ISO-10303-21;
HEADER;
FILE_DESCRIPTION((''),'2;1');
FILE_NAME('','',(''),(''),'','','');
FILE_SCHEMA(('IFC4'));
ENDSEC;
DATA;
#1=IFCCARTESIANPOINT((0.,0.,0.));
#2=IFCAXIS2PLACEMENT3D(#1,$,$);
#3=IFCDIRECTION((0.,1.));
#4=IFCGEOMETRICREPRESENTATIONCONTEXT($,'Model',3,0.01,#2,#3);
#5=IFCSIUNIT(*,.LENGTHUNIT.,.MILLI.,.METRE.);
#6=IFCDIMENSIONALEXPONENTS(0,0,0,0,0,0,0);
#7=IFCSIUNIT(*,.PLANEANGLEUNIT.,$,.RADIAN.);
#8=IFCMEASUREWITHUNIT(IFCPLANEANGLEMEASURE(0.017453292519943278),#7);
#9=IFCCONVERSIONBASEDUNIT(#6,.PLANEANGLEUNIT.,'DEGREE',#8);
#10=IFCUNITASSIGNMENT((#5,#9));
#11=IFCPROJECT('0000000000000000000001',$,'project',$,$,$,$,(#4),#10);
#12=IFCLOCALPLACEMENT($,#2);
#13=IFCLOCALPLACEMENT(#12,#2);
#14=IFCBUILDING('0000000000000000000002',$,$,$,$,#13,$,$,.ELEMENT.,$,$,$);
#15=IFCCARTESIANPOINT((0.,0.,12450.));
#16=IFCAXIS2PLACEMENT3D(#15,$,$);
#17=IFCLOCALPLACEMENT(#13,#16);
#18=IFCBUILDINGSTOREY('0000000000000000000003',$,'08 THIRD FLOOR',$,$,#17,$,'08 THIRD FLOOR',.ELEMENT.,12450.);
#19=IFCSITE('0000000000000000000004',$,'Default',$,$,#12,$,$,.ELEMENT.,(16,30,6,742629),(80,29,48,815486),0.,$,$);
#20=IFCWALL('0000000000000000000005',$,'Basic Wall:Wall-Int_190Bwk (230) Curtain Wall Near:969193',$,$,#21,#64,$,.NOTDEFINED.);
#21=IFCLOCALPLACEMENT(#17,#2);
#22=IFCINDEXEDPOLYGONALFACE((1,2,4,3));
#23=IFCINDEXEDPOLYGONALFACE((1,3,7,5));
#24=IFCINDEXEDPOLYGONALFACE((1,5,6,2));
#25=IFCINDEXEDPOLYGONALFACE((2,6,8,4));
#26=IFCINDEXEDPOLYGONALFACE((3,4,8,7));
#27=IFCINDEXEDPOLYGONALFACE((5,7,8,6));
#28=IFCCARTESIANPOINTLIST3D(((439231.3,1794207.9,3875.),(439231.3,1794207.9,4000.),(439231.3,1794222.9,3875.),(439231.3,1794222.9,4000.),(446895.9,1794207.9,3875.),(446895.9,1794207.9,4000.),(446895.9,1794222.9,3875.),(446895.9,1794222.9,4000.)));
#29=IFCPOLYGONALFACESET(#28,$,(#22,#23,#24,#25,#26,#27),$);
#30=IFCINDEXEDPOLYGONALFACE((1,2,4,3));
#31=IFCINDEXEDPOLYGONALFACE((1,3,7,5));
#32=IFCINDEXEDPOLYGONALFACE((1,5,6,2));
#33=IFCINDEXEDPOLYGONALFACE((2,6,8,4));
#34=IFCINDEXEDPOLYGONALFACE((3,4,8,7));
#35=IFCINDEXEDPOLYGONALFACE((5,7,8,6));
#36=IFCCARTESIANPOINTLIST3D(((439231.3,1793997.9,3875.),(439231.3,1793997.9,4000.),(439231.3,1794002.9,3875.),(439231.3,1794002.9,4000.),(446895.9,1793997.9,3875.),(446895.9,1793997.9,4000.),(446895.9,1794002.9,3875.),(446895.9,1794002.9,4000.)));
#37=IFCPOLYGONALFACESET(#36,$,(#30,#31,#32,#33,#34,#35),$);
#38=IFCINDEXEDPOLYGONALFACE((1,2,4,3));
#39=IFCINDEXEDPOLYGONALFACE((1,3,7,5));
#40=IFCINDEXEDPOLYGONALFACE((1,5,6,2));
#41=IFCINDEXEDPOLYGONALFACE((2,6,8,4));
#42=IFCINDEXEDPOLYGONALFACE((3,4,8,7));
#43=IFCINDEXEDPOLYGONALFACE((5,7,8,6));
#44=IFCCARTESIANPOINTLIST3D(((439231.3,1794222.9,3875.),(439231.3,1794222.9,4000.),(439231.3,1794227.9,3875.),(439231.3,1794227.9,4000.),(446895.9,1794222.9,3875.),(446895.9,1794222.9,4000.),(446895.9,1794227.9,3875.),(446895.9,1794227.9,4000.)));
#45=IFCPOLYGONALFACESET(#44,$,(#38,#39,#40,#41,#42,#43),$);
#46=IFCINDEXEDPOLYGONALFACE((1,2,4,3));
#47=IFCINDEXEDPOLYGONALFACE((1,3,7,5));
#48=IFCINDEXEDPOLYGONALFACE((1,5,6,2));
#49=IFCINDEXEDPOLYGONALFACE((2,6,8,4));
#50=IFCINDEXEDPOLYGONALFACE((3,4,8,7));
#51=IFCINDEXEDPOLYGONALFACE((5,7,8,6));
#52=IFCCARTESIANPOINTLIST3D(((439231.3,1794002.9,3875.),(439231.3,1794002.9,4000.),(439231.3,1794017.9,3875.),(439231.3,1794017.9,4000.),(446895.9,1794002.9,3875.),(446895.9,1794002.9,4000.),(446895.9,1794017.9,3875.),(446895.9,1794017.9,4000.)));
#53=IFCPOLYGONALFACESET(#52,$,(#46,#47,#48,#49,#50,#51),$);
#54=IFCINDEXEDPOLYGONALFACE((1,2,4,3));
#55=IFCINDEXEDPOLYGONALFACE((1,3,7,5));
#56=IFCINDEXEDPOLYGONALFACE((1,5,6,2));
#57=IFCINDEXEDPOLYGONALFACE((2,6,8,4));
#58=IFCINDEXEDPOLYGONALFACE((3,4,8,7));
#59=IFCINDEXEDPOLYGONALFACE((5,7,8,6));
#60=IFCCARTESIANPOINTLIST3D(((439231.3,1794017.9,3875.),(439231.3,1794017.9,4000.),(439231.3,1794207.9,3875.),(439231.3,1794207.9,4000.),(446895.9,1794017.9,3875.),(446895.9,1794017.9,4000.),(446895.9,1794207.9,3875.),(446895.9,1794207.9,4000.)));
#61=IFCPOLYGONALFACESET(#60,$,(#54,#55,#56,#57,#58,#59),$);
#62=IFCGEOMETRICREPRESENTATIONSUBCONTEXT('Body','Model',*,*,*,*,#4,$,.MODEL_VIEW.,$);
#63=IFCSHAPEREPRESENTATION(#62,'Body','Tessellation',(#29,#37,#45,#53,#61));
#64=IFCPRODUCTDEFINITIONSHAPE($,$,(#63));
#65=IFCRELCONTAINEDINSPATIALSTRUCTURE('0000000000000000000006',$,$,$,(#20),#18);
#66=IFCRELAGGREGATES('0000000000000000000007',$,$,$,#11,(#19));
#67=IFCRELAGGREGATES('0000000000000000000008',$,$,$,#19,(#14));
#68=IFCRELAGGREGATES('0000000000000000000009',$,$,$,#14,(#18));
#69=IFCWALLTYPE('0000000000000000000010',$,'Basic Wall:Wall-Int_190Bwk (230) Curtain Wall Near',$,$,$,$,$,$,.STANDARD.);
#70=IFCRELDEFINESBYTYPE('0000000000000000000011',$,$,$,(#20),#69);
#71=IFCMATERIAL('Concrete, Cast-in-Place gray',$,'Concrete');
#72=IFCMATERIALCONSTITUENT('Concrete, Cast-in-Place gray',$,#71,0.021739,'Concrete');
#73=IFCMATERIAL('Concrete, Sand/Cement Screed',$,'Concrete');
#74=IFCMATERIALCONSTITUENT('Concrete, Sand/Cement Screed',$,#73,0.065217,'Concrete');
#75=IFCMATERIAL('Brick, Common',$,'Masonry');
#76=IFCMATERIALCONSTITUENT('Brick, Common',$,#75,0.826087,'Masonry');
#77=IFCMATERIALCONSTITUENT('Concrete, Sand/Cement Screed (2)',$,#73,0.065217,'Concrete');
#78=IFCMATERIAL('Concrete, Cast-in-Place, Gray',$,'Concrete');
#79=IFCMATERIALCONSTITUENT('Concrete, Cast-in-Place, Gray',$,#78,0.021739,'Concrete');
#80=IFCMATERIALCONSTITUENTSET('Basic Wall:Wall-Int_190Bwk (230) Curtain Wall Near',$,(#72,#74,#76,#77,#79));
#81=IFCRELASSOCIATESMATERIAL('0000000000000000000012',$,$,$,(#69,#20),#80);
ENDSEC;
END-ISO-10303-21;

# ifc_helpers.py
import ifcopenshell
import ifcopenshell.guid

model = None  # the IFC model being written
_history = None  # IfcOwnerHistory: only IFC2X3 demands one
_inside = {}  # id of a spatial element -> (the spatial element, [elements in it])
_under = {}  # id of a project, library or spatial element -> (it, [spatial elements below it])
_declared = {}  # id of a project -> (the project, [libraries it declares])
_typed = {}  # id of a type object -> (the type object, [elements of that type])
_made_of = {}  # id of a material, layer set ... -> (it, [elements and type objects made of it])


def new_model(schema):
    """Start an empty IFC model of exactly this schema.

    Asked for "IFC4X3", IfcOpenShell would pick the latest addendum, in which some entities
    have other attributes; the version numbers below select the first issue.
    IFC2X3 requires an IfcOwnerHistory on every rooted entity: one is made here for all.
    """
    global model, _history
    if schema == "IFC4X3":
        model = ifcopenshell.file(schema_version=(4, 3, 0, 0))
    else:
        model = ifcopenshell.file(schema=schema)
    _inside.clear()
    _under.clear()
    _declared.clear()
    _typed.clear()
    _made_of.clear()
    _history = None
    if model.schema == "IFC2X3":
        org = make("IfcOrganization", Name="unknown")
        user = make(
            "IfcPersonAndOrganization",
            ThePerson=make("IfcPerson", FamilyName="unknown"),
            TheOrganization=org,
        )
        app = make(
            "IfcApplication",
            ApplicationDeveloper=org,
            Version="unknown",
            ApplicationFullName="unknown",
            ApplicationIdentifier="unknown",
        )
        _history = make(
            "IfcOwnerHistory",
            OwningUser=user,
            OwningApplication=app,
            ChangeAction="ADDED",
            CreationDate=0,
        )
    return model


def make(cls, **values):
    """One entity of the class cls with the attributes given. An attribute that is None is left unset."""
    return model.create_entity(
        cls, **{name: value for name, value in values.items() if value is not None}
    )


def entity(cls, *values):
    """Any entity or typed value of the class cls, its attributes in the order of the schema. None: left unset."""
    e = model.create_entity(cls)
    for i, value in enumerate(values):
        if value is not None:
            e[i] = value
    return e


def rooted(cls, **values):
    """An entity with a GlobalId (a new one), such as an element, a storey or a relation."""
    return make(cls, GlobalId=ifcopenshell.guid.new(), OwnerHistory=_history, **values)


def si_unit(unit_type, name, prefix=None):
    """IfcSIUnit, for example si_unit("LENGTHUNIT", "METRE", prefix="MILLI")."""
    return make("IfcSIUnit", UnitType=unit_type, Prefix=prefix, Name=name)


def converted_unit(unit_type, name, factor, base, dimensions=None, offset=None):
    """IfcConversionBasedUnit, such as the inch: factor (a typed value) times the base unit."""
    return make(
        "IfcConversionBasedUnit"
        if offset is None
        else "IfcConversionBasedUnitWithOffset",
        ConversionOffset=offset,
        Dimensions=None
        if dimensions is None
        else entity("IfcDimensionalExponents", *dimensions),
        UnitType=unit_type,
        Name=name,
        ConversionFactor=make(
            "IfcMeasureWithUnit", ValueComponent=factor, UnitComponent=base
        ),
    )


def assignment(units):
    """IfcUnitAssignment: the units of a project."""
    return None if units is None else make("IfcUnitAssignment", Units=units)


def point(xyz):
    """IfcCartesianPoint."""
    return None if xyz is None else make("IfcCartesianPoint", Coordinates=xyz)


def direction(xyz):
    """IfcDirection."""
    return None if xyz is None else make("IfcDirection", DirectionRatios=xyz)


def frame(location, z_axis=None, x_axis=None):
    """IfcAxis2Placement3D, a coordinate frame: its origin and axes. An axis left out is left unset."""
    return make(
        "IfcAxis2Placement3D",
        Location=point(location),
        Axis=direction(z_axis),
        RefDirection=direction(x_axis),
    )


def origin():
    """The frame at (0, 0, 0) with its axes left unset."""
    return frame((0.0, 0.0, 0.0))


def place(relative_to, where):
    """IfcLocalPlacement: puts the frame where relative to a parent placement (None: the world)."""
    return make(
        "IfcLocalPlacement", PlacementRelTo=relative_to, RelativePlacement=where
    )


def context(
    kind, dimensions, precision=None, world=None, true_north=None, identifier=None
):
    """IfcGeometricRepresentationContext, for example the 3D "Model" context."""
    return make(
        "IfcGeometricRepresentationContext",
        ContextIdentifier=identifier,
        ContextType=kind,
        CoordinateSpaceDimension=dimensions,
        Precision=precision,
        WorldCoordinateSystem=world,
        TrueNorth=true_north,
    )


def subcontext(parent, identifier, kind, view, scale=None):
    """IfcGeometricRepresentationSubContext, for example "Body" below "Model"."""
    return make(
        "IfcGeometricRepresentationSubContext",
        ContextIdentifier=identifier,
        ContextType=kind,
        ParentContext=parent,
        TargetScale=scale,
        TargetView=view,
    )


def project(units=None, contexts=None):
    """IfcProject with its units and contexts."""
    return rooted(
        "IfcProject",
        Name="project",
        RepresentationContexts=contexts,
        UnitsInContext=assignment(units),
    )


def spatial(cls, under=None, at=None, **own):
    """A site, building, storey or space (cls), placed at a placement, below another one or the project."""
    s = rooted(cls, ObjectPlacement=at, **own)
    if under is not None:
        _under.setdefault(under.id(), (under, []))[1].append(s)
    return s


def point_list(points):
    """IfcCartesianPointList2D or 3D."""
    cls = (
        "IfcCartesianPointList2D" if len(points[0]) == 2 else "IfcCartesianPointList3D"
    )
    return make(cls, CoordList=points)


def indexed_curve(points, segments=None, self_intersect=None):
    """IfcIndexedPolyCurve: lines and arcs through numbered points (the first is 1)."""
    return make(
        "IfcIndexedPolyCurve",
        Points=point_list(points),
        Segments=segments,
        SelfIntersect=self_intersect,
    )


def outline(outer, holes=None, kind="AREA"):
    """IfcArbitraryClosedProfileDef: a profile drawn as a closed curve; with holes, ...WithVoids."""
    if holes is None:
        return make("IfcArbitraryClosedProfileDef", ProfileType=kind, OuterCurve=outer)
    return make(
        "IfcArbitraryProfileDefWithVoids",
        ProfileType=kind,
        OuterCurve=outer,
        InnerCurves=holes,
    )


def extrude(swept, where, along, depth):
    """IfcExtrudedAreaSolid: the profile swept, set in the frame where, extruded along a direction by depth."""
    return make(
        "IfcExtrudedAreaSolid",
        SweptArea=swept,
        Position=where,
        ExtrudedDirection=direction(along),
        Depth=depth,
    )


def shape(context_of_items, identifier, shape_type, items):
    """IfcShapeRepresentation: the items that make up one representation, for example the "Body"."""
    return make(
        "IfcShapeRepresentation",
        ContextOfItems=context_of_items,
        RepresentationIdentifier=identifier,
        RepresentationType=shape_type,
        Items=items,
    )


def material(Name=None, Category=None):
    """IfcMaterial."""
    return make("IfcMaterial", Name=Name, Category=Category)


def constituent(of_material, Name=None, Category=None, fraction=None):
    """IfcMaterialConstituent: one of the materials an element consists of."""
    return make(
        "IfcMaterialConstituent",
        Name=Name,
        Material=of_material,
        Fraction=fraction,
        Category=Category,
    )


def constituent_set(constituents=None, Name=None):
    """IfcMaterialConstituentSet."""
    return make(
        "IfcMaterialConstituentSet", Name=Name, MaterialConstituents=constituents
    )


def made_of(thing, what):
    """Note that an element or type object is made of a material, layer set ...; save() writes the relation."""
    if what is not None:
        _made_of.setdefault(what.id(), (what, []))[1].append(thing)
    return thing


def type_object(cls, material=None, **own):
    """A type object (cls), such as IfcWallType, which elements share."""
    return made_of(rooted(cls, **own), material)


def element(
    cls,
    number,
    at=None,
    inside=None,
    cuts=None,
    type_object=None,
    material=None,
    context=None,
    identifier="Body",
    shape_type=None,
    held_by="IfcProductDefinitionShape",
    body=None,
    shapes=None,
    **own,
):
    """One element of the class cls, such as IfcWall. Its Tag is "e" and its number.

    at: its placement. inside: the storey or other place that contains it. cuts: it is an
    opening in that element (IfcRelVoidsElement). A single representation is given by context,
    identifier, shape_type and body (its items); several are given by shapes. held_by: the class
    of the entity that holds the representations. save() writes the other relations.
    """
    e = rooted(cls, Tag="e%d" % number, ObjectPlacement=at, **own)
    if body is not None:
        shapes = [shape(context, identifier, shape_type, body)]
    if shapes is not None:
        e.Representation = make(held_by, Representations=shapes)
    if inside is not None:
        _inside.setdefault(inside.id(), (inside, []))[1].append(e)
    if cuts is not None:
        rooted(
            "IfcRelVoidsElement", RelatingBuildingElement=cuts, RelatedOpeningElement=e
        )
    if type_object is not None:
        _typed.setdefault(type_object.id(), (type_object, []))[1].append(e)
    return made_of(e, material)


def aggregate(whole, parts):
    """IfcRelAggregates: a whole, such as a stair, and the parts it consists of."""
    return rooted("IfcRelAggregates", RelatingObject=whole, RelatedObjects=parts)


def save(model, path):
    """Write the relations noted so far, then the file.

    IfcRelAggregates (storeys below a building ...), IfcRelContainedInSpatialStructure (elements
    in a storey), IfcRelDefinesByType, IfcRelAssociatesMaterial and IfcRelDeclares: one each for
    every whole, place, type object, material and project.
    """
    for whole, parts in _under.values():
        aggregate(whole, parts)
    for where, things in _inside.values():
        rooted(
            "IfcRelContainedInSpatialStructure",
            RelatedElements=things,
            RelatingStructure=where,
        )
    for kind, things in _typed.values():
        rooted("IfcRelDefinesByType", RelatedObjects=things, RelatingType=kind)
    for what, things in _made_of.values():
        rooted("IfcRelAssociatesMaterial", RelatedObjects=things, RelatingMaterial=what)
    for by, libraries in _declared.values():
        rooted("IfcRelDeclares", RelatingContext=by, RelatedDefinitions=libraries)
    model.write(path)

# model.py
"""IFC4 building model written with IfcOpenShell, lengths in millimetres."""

from ifc_helpers import new_model, entity, si_unit, converted_unit, direction, frame, origin, place, context, subcontext, project, spatial, indexed_curve, outline, extrude, material, constituent, constituent_set, type_object, element, save


model = new_model("IFC4")

# Units and contexts
model_context = context("Model", 3, precision=0.01, world=origin(), true_north=direction((0.0, 1.0)))
body_context = subcontext(model_context, "Body", "Model", "MODEL_VIEW")
ifc_project = project(units=[si_unit("LENGTHUNIT", "METRE", prefix="MILLI"), converted_unit("PLANEANGLEUNIT", "DEGREE", entity("IfcPlaneAngleMeasure", 0.017453292519943278), si_unit("PLANEANGLEUNIT", "RADIAN"), dimensions=[0, 0, 0, 0, 0, 0, 0])], contexts=[model_context])

# Site, building, storey
site_placement = place(None, origin())
site = spatial("IfcSite", under=ifc_project, at=site_placement, Name="Default", CompositionType="ELEMENT", RefLatitude=(16, 30, 6, 742629), RefLongitude=(80, 29, 48, 815486), RefElevation=0.0)
building_placement = place(site_placement, origin())
building = spatial("IfcBuilding", under=site, at=building_placement, CompositionType="ELEMENT")
storey_placement = place(building_placement, frame((0.0, 0.0, 12450.0)))
storey = spatial("IfcBuildingStorey", under=building, at=storey_placement, Name="08 THIRD FLOOR", LongName="08 THIRD FLOOR", CompositionType="ELEMENT", Elevation=12450.0)

# Shared definitions
ifc_material_1 = material(Name="Concrete, Sand/Cement Screed", Category="Concrete")
ifc_material_2 = material(Name="Brick, Common", Category="Masonry")

# Wall
ifc_material_3 = material(Name="Concrete, Cast-in-Place gray", Category="Concrete")
ifc_constituent_1 = constituent(ifc_material_3, Name="Concrete, Cast-in-Place gray", Category="Concrete", fraction=0.021739)
ifc_constituent_2 = constituent(ifc_material_1, Name="Concrete, Sand/Cement Screed", Category="Concrete", fraction=0.065217)
ifc_constituent_3 = constituent(ifc_material_2, Name="Brick, Common", Category="Masonry", fraction=0.826087)
ifc_constituent_4 = constituent(ifc_material_1, Name="Concrete, Sand/Cement Screed (2)", Category="Concrete", fraction=0.065217)
ifc_material_4 = material(Name="Concrete, Cast-in-Place, Gray", Category="Concrete")
ifc_constituent_5 = constituent(ifc_material_4, Name="Concrete, Cast-in-Place, Gray", Category="Concrete", fraction=0.021739)
ifc_constituent_set_1 = constituent_set(constituents=[ifc_constituent_1, ifc_constituent_2, ifc_constituent_3, ifc_constituent_4, ifc_constituent_5], Name="Basic Wall:Wall-Int_190Bwk (230) Curtain Wall Near")
wall_type_1 = type_object("IfcWallType", Name="Basic Wall:Wall-Int_190Bwk (230) Curtain Wall Near", PredefinedType="STANDARD", material=ifc_constituent_set_1)
wall_1_placement = place(storey_placement, frame((439231.3, 1794112.9, 3875.0)))
element("IfcWall", 1, at=wall_1_placement, inside=storey, type_object=wall_type_1, material=ifc_constituent_set_1, Name="Basic Wall:Wall-Int_190Bwk (230) Curtain Wall Near:969193", PredefinedType="NOTDEFINED", context=body_context, shape_type="SweptSolid", body=[
    extrude(outline(indexed_curve([(-3832.3, -7.5), (3832.3, -7.5), (3832.3, 7.5), (-3832.3, 7.5), (-3832.3, -7.5)], self_intersect=False)), frame((3832.3, 102.5, 0.0)), (0.0, 0.0, 1.0), 125.0),
    extrude(outline(indexed_curve([(-2.5, -3832.3), (2.5, -3832.3), (2.5, 3832.3), (-2.5, 3832.3), (-2.5, -3832.3)], self_intersect=False)), frame((3832.3, -112.5, 0.0), z_axis=(0.0, 0.0, 1.0), x_axis=(0.0, 1.0, 0.0)), (0.0, 0.0, 1.0), 125.0),
    extrude(outline(indexed_curve([(-2.5, -3832.3), (2.5, -3832.3), (2.5, 3832.3), (-2.5, 3832.3), (-2.5, -3832.3)], self_intersect=False)), frame((3832.3, 112.5, 0.0), z_axis=(0.0, 0.0, 1.0), x_axis=(0.0, -1.0, 0.0)), (0.0, 0.0, 1.0), 125.0),
    extrude(outline(indexed_curve([(-3832.3, -7.5), (3832.3, -7.5), (3832.3, 7.5), (-3832.3, 7.5), (-3832.3, -7.5)], self_intersect=False)), frame((3832.3, -102.5, 0.0)), (0.0, 0.0, 1.0), 125.0),
    extrude(outline(indexed_curve([(-3832.3, -95.0), (3832.3, -95.0), (3832.3, 95.0), (-3832.3, 95.0), (-3832.3, -95.0)], self_intersect=False)), frame((3832.3, 0.0, 0.0)), (0.0, 0.0, 1.0), 125.0),
])

save(model, "model.ifc")
